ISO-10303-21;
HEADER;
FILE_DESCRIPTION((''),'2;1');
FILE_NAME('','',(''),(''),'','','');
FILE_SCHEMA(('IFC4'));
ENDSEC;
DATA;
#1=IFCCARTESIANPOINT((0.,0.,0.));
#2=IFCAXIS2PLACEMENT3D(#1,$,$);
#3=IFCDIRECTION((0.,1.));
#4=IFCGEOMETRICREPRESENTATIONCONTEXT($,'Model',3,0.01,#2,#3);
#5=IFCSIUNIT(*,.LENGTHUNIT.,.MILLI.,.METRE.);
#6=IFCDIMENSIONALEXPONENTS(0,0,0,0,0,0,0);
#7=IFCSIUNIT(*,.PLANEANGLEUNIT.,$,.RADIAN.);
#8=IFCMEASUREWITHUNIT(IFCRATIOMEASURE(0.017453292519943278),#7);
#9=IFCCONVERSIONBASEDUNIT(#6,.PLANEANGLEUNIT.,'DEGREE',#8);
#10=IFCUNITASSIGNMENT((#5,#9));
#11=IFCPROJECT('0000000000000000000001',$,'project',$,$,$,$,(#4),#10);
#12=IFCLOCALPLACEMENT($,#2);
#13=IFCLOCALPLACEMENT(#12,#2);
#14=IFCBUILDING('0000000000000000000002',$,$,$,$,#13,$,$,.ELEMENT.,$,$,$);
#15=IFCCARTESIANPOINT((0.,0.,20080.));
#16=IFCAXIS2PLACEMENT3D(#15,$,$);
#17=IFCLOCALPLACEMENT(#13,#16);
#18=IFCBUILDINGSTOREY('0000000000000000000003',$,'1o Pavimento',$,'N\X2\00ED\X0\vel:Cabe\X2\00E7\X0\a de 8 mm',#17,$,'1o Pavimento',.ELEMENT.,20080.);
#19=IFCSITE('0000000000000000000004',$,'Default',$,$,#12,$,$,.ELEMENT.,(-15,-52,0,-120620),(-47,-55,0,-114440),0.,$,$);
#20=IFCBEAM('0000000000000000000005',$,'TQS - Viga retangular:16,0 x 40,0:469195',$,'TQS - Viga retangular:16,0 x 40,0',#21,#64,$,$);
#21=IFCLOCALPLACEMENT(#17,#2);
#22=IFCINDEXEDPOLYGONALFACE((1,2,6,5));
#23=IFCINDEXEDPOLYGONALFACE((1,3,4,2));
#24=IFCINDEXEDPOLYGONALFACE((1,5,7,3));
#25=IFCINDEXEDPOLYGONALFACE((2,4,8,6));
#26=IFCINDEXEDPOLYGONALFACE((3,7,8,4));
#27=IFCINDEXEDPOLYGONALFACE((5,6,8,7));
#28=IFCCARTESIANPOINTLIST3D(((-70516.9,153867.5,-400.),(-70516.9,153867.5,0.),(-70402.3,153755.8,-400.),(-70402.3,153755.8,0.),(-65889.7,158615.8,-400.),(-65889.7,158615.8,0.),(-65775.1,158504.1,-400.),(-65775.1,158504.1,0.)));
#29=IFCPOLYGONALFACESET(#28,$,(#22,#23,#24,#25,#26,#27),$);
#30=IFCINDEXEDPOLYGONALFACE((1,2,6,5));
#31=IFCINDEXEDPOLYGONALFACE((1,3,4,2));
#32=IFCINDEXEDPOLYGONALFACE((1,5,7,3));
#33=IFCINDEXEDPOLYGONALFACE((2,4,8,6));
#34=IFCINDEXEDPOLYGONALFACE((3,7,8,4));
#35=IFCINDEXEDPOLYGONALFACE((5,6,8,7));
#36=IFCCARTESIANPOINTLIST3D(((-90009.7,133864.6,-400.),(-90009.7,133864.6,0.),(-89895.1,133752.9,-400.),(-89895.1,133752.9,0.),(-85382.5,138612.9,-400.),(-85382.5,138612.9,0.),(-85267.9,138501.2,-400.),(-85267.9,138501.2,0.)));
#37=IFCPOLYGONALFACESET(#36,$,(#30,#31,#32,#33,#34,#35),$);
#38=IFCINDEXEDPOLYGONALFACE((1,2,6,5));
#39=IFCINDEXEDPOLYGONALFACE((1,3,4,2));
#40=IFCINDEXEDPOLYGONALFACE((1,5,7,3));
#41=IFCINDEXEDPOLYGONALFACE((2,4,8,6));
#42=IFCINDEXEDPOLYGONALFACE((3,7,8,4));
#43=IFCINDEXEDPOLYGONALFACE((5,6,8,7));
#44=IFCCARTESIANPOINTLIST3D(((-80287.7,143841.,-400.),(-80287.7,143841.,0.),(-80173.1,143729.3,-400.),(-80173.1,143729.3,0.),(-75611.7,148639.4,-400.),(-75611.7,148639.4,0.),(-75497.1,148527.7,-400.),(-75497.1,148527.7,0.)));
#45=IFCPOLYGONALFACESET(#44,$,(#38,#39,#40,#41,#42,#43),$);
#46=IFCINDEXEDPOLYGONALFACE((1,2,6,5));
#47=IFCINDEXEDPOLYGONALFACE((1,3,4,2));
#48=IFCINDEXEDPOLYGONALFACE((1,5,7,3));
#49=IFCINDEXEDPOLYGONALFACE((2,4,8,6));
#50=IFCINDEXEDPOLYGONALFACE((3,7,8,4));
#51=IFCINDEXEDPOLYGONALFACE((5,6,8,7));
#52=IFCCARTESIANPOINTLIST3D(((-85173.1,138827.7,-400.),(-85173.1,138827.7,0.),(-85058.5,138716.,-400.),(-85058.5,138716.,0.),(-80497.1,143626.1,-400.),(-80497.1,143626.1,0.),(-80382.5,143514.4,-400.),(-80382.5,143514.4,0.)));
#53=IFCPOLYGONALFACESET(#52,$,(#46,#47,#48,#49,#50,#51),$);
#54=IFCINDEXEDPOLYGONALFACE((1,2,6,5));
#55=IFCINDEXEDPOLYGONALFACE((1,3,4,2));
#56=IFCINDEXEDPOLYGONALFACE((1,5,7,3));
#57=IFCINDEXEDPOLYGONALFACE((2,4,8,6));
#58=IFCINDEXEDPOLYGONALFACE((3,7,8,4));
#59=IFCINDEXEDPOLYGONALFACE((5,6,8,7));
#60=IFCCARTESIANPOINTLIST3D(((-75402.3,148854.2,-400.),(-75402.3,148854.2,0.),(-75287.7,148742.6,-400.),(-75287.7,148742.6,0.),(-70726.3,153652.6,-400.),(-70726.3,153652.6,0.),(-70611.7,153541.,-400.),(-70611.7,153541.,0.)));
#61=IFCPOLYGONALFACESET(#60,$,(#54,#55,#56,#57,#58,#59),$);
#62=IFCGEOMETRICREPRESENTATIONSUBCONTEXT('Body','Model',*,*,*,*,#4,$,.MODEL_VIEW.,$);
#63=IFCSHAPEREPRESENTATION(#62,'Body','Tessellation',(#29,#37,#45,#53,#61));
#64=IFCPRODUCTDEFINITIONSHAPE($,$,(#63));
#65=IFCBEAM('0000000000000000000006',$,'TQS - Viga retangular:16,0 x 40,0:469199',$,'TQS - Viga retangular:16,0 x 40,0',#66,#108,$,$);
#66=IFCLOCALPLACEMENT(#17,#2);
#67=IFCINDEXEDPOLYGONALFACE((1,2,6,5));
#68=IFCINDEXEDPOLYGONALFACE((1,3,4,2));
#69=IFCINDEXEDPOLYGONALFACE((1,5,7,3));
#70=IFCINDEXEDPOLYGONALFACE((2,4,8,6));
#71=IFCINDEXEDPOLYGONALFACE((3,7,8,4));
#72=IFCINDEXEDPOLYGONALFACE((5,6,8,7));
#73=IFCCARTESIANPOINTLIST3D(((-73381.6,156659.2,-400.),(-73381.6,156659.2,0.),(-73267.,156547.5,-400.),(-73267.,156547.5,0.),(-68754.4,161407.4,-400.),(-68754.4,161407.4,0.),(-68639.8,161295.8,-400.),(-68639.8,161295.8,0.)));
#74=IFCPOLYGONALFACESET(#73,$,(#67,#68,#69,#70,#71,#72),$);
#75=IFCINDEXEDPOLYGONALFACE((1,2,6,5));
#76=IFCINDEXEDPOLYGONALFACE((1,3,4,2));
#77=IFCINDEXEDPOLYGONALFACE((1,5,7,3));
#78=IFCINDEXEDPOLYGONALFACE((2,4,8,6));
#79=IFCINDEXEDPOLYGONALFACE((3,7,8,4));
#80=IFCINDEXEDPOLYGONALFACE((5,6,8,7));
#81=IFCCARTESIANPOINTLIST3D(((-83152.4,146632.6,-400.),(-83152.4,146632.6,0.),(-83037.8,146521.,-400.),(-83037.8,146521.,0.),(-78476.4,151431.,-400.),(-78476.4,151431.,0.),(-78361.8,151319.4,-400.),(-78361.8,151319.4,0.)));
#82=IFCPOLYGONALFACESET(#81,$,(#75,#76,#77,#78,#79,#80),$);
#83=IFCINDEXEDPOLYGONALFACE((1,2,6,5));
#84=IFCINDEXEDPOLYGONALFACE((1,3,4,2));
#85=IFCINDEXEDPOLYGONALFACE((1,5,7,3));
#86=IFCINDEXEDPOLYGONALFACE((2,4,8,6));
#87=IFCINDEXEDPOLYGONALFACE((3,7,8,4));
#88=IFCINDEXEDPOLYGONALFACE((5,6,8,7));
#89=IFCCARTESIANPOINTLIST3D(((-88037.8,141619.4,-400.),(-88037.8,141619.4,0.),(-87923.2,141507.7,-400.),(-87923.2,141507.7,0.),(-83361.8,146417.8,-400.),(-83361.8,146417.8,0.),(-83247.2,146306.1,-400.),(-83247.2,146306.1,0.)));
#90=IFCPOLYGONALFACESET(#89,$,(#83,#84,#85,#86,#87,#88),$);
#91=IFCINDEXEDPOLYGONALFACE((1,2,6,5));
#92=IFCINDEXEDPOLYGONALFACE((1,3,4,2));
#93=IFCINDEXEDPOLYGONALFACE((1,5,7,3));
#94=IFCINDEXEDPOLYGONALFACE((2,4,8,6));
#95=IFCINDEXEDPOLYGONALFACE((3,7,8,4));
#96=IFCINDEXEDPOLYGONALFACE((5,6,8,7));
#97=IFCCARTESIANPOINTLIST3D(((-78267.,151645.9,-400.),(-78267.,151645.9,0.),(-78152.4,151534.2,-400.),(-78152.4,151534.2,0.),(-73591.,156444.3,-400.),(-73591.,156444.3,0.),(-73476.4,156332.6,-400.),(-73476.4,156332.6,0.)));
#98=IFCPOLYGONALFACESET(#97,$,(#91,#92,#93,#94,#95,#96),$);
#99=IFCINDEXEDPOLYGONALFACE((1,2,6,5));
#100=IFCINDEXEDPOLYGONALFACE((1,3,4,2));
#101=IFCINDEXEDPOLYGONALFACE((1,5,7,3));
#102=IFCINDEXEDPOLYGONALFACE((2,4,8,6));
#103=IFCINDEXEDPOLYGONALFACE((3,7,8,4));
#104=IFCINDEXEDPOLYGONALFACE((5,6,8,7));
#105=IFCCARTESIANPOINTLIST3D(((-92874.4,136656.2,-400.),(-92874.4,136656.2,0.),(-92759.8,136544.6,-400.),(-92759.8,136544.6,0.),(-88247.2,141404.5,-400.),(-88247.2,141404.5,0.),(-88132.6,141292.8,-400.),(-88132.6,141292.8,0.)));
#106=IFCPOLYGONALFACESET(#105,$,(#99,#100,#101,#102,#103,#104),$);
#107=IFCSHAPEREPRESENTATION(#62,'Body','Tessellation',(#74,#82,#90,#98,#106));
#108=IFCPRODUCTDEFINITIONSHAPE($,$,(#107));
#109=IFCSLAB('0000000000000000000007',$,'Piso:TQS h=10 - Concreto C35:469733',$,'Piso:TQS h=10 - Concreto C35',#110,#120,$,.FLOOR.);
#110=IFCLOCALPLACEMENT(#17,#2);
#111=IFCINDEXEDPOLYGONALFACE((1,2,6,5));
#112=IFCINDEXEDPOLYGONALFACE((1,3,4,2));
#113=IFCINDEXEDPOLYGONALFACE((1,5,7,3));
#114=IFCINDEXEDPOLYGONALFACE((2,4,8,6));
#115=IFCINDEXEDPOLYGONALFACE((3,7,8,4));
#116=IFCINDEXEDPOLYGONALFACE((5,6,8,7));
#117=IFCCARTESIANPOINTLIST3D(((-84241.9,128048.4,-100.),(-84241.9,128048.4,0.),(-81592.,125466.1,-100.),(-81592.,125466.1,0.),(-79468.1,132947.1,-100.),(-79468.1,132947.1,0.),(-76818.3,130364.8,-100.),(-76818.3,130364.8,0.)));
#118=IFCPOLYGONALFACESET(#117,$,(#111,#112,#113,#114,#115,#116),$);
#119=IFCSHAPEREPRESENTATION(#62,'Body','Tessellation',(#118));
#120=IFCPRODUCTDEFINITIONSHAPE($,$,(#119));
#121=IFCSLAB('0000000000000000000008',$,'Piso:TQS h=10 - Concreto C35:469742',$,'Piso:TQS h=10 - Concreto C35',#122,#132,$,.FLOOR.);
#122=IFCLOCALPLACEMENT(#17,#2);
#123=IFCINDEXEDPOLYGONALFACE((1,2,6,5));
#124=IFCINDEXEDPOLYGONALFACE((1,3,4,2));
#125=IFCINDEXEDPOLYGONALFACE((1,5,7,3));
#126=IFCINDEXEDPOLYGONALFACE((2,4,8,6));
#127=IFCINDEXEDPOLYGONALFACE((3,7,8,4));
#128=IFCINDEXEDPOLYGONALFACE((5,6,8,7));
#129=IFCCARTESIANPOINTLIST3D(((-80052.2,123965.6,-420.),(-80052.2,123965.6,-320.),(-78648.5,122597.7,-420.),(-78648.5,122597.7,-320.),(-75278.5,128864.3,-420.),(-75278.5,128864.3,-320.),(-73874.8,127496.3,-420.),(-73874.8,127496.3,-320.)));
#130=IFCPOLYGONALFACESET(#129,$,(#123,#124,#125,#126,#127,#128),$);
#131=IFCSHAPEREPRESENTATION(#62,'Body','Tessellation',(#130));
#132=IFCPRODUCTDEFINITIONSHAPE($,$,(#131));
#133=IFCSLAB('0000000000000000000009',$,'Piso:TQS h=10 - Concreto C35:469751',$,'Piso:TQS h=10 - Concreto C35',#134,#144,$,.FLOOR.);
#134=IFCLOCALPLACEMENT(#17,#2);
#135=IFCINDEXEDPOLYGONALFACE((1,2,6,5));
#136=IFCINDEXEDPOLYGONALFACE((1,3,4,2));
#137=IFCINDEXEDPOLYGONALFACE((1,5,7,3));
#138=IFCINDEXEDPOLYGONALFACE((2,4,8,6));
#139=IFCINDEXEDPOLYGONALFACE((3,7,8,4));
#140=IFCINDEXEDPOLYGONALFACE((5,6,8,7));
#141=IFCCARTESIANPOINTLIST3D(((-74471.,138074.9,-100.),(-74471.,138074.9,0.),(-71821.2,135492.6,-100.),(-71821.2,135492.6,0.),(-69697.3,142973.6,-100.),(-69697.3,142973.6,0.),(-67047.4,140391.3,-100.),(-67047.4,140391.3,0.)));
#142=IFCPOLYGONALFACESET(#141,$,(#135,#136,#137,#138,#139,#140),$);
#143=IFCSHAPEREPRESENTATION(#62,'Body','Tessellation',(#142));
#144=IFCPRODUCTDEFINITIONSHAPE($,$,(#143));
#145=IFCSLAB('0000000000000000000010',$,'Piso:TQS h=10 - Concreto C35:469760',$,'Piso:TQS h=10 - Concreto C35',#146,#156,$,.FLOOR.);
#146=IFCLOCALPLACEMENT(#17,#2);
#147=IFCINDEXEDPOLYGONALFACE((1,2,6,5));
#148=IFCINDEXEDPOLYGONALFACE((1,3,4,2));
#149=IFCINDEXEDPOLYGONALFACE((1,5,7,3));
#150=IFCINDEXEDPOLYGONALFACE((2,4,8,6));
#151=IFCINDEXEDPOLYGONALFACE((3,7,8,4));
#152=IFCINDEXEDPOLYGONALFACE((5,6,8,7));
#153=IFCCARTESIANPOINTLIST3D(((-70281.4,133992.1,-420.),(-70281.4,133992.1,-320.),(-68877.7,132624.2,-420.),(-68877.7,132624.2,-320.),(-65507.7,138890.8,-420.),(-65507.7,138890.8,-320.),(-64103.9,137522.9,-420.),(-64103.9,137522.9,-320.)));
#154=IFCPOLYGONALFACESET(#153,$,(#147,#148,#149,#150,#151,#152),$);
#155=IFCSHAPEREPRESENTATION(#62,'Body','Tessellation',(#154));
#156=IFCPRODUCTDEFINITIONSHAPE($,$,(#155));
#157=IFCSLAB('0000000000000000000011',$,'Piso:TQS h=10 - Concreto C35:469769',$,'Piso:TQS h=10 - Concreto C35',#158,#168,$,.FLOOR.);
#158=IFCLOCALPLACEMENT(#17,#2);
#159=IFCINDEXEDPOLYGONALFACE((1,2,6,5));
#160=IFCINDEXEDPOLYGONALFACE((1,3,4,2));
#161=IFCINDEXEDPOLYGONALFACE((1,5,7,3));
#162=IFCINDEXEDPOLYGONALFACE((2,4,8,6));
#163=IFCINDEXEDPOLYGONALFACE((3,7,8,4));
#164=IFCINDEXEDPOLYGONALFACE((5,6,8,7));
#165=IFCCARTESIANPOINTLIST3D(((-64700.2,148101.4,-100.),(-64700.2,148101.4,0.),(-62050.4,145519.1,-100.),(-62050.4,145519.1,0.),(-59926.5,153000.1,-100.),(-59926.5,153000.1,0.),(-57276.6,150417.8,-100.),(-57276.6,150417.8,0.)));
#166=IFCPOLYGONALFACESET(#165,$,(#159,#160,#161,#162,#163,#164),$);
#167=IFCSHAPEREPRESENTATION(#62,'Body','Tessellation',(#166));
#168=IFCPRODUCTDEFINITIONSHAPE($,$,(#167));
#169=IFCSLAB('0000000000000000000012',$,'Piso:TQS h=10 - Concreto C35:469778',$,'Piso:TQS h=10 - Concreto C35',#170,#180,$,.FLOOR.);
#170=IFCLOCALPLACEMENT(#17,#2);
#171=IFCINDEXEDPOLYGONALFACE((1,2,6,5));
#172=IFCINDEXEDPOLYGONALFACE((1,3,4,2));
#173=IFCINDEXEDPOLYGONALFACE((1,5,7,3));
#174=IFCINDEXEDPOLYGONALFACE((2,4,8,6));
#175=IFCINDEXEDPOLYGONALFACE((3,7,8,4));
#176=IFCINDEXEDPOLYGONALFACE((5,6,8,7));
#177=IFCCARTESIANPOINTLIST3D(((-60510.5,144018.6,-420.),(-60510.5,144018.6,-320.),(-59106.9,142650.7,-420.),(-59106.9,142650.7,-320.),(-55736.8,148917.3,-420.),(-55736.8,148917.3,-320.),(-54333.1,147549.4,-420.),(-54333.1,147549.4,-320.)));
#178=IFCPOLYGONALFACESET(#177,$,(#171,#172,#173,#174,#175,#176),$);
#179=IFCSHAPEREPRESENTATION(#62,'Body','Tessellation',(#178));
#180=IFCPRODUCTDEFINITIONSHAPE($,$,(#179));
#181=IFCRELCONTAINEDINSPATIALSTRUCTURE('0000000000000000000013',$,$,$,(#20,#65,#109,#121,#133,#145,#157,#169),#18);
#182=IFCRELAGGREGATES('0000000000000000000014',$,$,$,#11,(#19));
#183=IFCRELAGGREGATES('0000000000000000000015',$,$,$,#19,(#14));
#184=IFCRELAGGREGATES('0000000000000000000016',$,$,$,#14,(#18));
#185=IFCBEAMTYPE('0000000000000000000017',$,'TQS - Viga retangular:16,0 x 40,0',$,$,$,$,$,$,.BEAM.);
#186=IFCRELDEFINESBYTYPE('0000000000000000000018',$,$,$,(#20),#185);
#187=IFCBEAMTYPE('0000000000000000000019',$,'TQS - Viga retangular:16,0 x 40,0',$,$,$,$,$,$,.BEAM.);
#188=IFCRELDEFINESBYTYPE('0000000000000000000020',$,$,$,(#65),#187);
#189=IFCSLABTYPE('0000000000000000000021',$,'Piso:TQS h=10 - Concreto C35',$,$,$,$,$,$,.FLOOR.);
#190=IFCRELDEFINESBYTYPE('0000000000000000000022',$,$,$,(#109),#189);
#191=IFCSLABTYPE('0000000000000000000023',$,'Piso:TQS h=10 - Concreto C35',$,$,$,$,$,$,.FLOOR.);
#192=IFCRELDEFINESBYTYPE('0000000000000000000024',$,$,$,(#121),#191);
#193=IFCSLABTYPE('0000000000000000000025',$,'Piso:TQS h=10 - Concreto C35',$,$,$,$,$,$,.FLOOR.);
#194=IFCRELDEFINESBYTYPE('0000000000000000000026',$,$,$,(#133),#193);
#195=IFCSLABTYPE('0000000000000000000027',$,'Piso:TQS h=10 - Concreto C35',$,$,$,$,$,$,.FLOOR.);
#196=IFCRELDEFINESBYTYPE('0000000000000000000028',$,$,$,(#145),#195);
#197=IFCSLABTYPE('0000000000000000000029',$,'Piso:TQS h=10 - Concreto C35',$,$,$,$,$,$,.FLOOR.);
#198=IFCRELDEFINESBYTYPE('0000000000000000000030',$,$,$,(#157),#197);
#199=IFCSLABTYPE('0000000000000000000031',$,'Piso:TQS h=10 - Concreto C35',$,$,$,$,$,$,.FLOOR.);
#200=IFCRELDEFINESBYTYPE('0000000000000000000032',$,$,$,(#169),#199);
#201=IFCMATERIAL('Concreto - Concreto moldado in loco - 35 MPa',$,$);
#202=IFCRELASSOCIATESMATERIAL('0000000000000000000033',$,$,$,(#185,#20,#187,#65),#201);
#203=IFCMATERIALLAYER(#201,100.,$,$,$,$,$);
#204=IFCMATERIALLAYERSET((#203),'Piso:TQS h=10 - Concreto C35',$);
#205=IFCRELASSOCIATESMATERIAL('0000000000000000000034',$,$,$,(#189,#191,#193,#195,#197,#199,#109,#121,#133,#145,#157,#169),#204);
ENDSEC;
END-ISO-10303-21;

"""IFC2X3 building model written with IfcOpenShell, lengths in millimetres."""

from ifc_helpers import new_model, entity, si_unit, converted_unit, direction, frame, frame_2d, origin, origin_2d_with_axis, place, context, subcontext, project, spatial, polyline, rectangle, outline, extrude, source, transform, mapped, material, layer, layer_set, layer_usage, type_object, type_shapes, element, save


model = new_model("IFC2X3")

# Units and contexts
model_context = context("Model", 3, precision=0.01, world=origin(), true_north=direction((0.0, 1.0)))
body_context = subcontext(model_context, "Body", "Model", "MODEL_VIEW")
ifc_project = project(units=[si_unit("LENGTHUNIT", "METRE", prefix="MILLI"), converted_unit("PLANEANGLEUNIT", "DEGREE", entity("IfcRatioMeasure", 0.017453292519943278), si_unit("PLANEANGLEUNIT", "RADIAN"), dimensions=[0, 0, 0, 0, 0, 0, 0])], contexts=[model_context])

# Site, building, storey
site_placement = place(None, origin())
site = spatial("IfcSite", under=ifc_project, at=site_placement, Name="Default", CompositionType="ELEMENT", RefLatitude=(-15, -52, 0, -120620), RefLongitude=(-47, -55, 0, -114440), RefElevation=0.0)
building_placement = place(site_placement, origin())
building = spatial("IfcBuilding", under=site, at=building_placement, CompositionType="ELEMENT")
storey_placement = place(building_placement, frame((0.0, 0.0, 20080.0)))
storey = spatial("IfcBuildingStorey", under=building, at=storey_placement, Name="1o Pavimento", ObjectType="Nível:Cabeça de 8 mm", LongName="1o Pavimento", CompositionType="ELEMENT", Elevation=20080.0)

# Shared definitions
ifc_material = material(Name="Concreto - Concreto moldado in loco - 35 MPa")

# Beams
beam_type_1 = type_object("IfcBeamType", Name="TQS - Viga retangular:16,0 x 40,0", PredefinedType="BEAM", material=ifc_material)
shared_shape_1 = source(origin(), body_context, "Body", "SweptSolid", [
    extrude(rectangle(XDim=400.0, YDim=160.0, at=frame_2d((0.0, 0.0), x_axis=(1.0, 0.0))), frame((-70459.6, 153811.7, 19880.0), z_axis=(0.697915, 0.71618, 0.0), x_axis=(0.0, 0.0, 1.0)), (0.0, 0.0, 1.0), 6630.0),
    extrude(rectangle(XDim=400.0, YDim=160.0, at=frame_2d((0.0, 0.0), x_axis=(1.0, 0.0))), frame((-89952.4, 133808.7, 19880.0), z_axis=(0.697915, 0.71618, 0.0), x_axis=(0.0, 0.0, 1.0)), (0.0, 0.0, 1.0), 6630.0),
    extrude(rectangle(XDim=400.0, YDim=160.0, at=frame_2d((0.0, 0.0), x_axis=(1.0, 0.0))), frame((-80230.4, 143785.1, 19880.0), z_axis=(0.697915, 0.71618, 0.0), x_axis=(0.0, 0.0, 1.0)), (0.0, 0.0, 1.0), 6700.0),
    extrude(rectangle(XDim=400.0, YDim=160.0, at=frame_2d((0.0, 0.0), x_axis=(1.0, 0.0))), frame((-85115.8, 138771.9, 19880.0), z_axis=(0.697915, 0.71618, 0.0), x_axis=(0.0, 0.0, 1.0)), (0.0, 0.0, 1.0), 6700.0),
    extrude(rectangle(XDim=400.0, YDim=160.0, at=frame_2d((0.0, 0.0), x_axis=(1.0, 0.0))), frame((-75345.0, 148798.4, 19880.0), z_axis=(0.697915, 0.71618, 0.0), x_axis=(0.0, 0.0, 1.0)), (0.0, 0.0, 1.0), 6700.0),
])
type_shapes(beam_type_1, [shared_shape_1])
beam_1_placement = place(storey_placement, frame((0.0, 0.0, -20080.0)))
element("IfcBeam", 1, at=beam_1_placement, inside=storey, type_object=beam_type_1, material=ifc_material, Name="TQS - Viga retangular:16,0 x 40,0:469195", ObjectType="TQS - Viga retangular:16,0 x 40,0", context=body_context, shape_type="MappedRepresentation", body=[
    mapped(shared_shape_1, transform((0.0, 0.0, 0.0), scale=1.0)),
])
beam_type_2 = type_object("IfcBeamType", Name="TQS - Viga retangular:16,0 x 40,0", PredefinedType="BEAM", material=ifc_material)
shared_shape_2 = source(origin(), body_context, "Body", "SweptSolid", [
    extrude(rectangle(XDim=400.0, YDim=160.0, at=frame_2d((0.0, 0.0), x_axis=(1.0, 0.0))), frame((-73324.3, 156603.3, 19880.0), z_axis=(0.697915, 0.71618, 0.0), x_axis=(0.0, 0.0, 1.0)), (0.0, 0.0, 1.0), 6630.0),
    extrude(rectangle(XDim=400.0, YDim=160.0, at=frame_2d((0.0, 0.0), x_axis=(1.0, 0.0))), frame((-83095.1, 146576.8, 19880.0), z_axis=(0.697915, 0.71618, 0.0), x_axis=(0.0, 0.0, 1.0)), (0.0, 0.0, 1.0), 6700.0),
    extrude(rectangle(XDim=400.0, YDim=160.0, at=frame_2d((0.0, 0.0), x_axis=(1.0, 0.0))), frame((-87980.5, 141563.5, 19880.0), z_axis=(0.697915, 0.71618, 0.0), x_axis=(0.0, 0.0, 1.0)), (0.0, 0.0, 1.0), 6700.0),
    extrude(rectangle(XDim=400.0, YDim=160.0, at=frame_2d((0.0, 0.0), x_axis=(1.0, 0.0))), frame((-78209.7, 151590.1, 19880.0), z_axis=(0.697915, 0.71618, 0.0), x_axis=(0.0, 0.0, 1.0)), (0.0, 0.0, 1.0), 6700.0),
    extrude(rectangle(XDim=400.0, YDim=160.0, at=frame_2d((0.0, 0.0), x_axis=(1.0, 0.0))), frame((-92817.1, 136600.4, 19880.0), z_axis=(0.697915, 0.71618, 0.0), x_axis=(0.0, 0.0, 1.0)), (0.0, 0.0, 1.0), 6630.0),
])
type_shapes(beam_type_2, [shared_shape_2])
beam_2_placement = place(storey_placement, frame((0.0, 0.0, -20080.0)))
element("IfcBeam", 2, at=beam_2_placement, inside=storey, type_object=beam_type_2, material=ifc_material, Name="TQS - Viga retangular:16,0 x 40,0:469199", ObjectType="TQS - Viga retangular:16,0 x 40,0", context=body_context, shape_type="MappedRepresentation", body=[
    mapped(shared_shape_2, transform((0.0, 0.0, 0.0), scale=1.0)),
])

# Slabs
ifc_layer = layer(ifc_material, 100.0)
ifc_layer_set = layer_set([ifc_layer], Name="Piso:TQS h=10 - Concreto C35")
ifc_layer_usage_1 = layer_usage(ifc_layer_set, "AXIS3", "POSITIVE", 0.0)
slab_type_1 = type_object("IfcSlabType", Name="Piso:TQS h=10 - Concreto C35", PredefinedType="FLOOR", material=ifc_layer_set)
slab_1_placement = place(storey_placement, origin())
element("IfcSlab", 3, at=slab_1_placement, inside=storey, type_object=slab_type_1, material=ifc_layer_usage_1, Name="Piso:TQS h=10 - Concreto C35:469733", ObjectType="Piso:TQS h=10 - Concreto C35", PredefinedType="FLOOR", context=body_context, shape_type="SweptSolid", body=[
    extrude(rectangle(XDim=6840.0, YDim=3700.0, at=frame_2d((0.0, 0.0), x_axis=(1.0, 0.0))), frame((-80530.1, 129206.6, 0.0), z_axis=(0.0, 0.0, -1.0), x_axis=(-0.697915, -0.71618, 0.0)), (0.0, 0.0, 1.0), 100.0),
])
ifc_layer_usage_2 = layer_usage(ifc_layer_set, "AXIS3", "POSITIVE", 0.0)
slab_type_2 = type_object("IfcSlabType", Name="Piso:TQS h=10 - Concreto C35", PredefinedType="FLOOR", material=ifc_layer_set)
slab_2_placement = place(storey_placement, origin())
element("IfcSlab", 4, at=slab_2_placement, inside=storey, type_object=slab_type_2, material=ifc_layer_usage_2, Name="Piso:TQS h=10 - Concreto C35:469742", ObjectType="Piso:TQS h=10 - Concreto C35", PredefinedType="FLOOR", context=body_context, shape_type="SweptSolid", body=[
    extrude(rectangle(XDim=1960.0, YDim=6840.0, at=origin_2d_with_axis()), frame((-76963.5, 125731.0, -320.0), z_axis=(0.0, 0.0, -1.0), x_axis=(0.71618, -0.697915, 0.0)), (0.0, 0.0, 1.0), 100.0),
])
ifc_layer_usage_3 = layer_usage(ifc_layer_set, "AXIS3", "POSITIVE", 0.0)
slab_type_3 = type_object("IfcSlabType", Name="Piso:TQS h=10 - Concreto C35", PredefinedType="FLOOR", material=ifc_layer_set)
slab_3_placement = place(storey_placement, origin())
element("IfcSlab", 5, at=slab_3_placement, inside=storey, type_object=slab_type_3, material=ifc_layer_usage_3, Name="Piso:TQS h=10 - Concreto C35:469751", ObjectType="Piso:TQS h=10 - Concreto C35", PredefinedType="FLOOR", context=body_context, shape_type="SweptSolid", body=[
    extrude(rectangle(XDim=3700.0, YDim=6840.0, at=frame_2d((0.0, 0.0), x_axis=(1.0, 0.0))), frame((-70759.2, 139233.1, 0.0), z_axis=(0.0, 0.0, -1.0), x_axis=(0.71618, -0.697915, 0.0)), (0.0, 0.0, 1.0), 100.0),
])
ifc_layer_usage_4 = layer_usage(ifc_layer_set, "AXIS3", "POSITIVE", 0.0)
slab_type_4 = type_object("IfcSlabType", Name="Piso:TQS h=10 - Concreto C35", PredefinedType="FLOOR", material=ifc_layer_set)
slab_4_placement = place(storey_placement, origin())
element("IfcSlab", 6, at=slab_4_placement, inside=storey, type_object=slab_type_4, material=ifc_layer_usage_4, Name="Piso:TQS h=10 - Concreto C35:469760", ObjectType="Piso:TQS h=10 - Concreto C35", PredefinedType="FLOOR", context=body_context, shape_type="SweptSolid", body=[
    extrude(rectangle(XDim=6840.0, YDim=1960.0, at=frame_2d((0.0, 0.0), x_axis=(1.0, 0.0))), frame((-67192.7, 135757.5, -320.0), z_axis=(0.0, 0.0, -1.0), x_axis=(-0.697915, -0.71618, 0.0)), (0.0, 0.0, 1.0), 100.0),
])
ifc_layer_usage_5 = layer_usage(ifc_layer_set, "AXIS3", "POSITIVE", 0.0)
slab_type_5 = type_object("IfcSlabType", Name="Piso:TQS h=10 - Concreto C35", PredefinedType="FLOOR", material=ifc_layer_set)
slab_5_placement = place(storey_placement, origin())
element("IfcSlab", 7, at=slab_5_placement, inside=storey, type_object=slab_type_5, material=ifc_layer_usage_5, Name="Piso:TQS h=10 - Concreto C35:469769", ObjectType="Piso:TQS h=10 - Concreto C35", PredefinedType="FLOOR", context=body_context, shape_type="SweptSolid", body=[
    extrude(rectangle(XDim=3700.0, YDim=6840.0, at=origin_2d_with_axis()), frame((-60988.4, 149259.6, 0.0), z_axis=(0.0, 0.0, -1.0), x_axis=(0.71618, -0.697915, 0.0)), (0.0, 0.0, 1.0), 100.0),
])
ifc_layer_usage_6 = layer_usage(ifc_layer_set, "AXIS3", "POSITIVE", 0.0)
slab_type_6 = type_object("IfcSlabType", Name="Piso:TQS h=10 - Concreto C35", PredefinedType="FLOOR", material=ifc_layer_set)
slab_6_placement = place(storey_placement, origin())
element("IfcSlab", 8, at=slab_6_placement, inside=storey, type_object=slab_type_6, material=ifc_layer_usage_6, Name="Piso:TQS h=10 - Concreto C35:469778", ObjectType="Piso:TQS h=10 - Concreto C35", PredefinedType="FLOOR", context=body_context, shape_type="SweptSolid", body=[
    extrude(outline(polyline([(-3420.0, -980.0), (3420.0, -980.0), (3420.0, 980.0), (-3420.0, 980.0), (-3420.0, -980.0)])), frame((-57421.8, 145784.0, -320.0), z_axis=(0.0, 0.0, -1.0), x_axis=(-0.697915, -0.71618, 0.0)), (0.0, 0.0, 1.0), 100.0),
])

save(model, "model.ifc")
